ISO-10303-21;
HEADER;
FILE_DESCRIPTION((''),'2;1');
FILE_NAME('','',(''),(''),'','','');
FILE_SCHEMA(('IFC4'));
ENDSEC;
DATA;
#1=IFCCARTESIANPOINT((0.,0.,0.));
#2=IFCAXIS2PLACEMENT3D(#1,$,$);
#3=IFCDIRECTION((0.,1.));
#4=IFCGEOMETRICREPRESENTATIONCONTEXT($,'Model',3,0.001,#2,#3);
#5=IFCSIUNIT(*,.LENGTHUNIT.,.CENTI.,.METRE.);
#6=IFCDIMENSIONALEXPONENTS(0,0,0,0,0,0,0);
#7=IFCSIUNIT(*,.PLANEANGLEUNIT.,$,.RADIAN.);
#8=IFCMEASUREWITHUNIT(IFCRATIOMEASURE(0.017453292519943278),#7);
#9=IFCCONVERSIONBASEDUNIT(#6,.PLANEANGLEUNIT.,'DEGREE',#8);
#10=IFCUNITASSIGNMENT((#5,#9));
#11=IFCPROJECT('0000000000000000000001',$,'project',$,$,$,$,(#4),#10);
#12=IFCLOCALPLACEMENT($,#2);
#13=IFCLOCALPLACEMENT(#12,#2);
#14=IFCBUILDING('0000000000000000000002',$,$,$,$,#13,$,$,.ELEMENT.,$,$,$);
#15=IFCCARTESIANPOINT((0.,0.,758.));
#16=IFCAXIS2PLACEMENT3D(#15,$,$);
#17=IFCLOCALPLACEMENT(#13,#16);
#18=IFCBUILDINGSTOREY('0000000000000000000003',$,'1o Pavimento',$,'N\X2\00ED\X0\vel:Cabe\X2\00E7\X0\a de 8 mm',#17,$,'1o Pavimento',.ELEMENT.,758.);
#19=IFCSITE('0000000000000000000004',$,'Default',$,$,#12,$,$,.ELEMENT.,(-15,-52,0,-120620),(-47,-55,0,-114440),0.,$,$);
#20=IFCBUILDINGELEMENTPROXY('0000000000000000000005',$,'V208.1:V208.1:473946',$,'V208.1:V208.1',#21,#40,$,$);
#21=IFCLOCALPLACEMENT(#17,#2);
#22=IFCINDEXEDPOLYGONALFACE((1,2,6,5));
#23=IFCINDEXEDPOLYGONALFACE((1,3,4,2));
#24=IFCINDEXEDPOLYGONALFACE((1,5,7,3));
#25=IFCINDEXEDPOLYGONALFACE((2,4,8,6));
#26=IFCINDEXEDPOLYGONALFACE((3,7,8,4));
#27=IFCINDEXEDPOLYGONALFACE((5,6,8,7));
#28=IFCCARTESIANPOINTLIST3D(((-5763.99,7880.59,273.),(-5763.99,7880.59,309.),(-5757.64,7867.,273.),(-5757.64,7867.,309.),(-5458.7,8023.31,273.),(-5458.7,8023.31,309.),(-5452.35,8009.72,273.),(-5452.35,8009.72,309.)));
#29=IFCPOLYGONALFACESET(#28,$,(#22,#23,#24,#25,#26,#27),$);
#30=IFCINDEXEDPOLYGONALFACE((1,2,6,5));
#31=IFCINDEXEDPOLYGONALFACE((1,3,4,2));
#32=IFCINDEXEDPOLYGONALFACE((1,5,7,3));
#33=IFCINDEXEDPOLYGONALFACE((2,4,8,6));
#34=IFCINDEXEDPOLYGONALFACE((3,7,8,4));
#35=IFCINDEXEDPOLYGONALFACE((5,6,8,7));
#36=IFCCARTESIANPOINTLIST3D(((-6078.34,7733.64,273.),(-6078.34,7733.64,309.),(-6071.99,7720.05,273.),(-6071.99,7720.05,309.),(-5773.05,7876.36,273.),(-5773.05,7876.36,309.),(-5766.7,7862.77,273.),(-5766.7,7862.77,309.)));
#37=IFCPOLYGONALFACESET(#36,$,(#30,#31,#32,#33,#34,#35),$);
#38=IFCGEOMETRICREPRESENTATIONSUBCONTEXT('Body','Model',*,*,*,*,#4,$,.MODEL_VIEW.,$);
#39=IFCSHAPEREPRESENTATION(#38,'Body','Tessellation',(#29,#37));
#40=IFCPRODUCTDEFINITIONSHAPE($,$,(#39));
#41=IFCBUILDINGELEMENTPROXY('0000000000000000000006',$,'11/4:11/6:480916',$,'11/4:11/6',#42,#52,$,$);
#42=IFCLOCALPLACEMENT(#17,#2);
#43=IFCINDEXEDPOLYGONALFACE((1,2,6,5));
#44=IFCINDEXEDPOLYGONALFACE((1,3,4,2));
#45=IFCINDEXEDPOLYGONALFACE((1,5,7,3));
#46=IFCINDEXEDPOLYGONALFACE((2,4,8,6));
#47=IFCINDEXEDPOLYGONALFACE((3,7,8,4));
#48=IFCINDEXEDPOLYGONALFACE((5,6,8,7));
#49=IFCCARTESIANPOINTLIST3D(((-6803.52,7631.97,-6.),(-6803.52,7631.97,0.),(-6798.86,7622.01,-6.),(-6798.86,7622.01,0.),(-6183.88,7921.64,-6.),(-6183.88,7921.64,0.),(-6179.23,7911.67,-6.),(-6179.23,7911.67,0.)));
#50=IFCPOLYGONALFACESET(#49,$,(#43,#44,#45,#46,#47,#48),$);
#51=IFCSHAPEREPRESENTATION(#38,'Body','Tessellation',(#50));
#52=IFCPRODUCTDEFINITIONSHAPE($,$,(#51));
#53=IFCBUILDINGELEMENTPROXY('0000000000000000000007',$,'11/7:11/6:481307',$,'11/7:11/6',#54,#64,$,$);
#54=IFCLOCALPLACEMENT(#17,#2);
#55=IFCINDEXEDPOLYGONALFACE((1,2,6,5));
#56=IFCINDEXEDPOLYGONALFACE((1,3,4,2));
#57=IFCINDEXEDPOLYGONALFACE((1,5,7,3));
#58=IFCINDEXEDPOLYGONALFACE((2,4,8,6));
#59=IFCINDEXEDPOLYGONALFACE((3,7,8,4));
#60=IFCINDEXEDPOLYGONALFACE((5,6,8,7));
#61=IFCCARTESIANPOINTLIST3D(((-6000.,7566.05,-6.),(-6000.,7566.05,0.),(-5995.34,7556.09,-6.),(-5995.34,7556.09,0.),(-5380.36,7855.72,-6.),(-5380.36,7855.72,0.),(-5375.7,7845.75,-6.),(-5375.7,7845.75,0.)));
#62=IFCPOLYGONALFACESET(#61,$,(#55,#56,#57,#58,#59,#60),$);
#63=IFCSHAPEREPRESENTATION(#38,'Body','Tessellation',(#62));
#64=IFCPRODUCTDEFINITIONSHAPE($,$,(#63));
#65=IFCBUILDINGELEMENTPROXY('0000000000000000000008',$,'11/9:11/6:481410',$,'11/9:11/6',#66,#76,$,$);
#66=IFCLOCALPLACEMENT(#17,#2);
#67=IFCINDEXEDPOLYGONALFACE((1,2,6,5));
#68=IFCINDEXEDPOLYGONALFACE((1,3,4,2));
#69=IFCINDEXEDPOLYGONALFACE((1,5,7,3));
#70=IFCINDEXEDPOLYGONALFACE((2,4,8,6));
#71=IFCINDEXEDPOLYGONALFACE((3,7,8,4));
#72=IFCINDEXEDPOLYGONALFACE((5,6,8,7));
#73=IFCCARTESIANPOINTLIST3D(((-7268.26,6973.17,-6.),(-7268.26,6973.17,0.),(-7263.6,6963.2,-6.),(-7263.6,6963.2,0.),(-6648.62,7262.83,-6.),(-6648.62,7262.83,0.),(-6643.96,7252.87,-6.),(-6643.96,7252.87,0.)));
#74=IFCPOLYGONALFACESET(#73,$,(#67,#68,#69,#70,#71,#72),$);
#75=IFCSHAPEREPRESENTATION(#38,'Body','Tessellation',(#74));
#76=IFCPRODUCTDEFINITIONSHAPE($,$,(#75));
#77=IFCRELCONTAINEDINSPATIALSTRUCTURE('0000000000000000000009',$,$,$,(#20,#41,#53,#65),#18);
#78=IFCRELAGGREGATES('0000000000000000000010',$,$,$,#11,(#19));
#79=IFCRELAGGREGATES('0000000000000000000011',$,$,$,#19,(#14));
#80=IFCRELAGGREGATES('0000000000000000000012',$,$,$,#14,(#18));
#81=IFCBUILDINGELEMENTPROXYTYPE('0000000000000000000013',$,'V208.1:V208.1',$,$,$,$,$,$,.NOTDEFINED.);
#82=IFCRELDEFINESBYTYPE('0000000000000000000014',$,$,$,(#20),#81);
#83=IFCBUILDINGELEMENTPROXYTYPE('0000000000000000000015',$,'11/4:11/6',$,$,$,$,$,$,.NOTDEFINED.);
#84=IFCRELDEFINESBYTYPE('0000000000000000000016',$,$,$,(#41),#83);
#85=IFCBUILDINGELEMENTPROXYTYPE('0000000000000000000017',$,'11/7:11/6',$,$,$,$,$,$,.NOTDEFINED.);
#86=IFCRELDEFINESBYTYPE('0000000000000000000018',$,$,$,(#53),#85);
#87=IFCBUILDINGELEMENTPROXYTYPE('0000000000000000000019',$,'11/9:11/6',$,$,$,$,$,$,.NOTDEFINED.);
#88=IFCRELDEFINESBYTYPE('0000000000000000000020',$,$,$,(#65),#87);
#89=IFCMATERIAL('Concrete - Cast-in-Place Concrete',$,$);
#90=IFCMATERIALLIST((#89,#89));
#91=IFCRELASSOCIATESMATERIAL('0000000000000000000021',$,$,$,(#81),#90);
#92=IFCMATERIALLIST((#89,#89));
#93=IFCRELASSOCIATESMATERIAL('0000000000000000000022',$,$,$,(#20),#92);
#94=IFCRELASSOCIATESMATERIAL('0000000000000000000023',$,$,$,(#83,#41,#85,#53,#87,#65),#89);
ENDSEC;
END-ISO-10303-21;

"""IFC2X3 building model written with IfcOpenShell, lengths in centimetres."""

from ifc_helpers import new_model, entity, si_unit, converted_unit, direction, frame, frame_2d, origin, origin_2d_with_axis, place, context, subcontext, project, spatial, rectangle, extrude, source, transform, mapped, material, material_list, type_object, type_shapes, element, save


model = new_model("IFC2X3")

# Units and contexts
model_context = context("Model", 3, precision=0.001, world=origin(), true_north=direction((0.0, 1.0)))
body_context = subcontext(model_context, "Body", "Model", "MODEL_VIEW")
ifc_project = project(units=[si_unit("LENGTHUNIT", "METRE", prefix="CENTI"), converted_unit("PLANEANGLEUNIT", "DEGREE", entity("IfcRatioMeasure", 0.017453292519943278), si_unit("PLANEANGLEUNIT", "RADIAN"), dimensions=[0, 0, 0, 0, 0, 0, 0])], contexts=[model_context])

# Site, building, storey
site_placement = place(None, origin())
site = spatial("IfcSite", under=ifc_project, at=site_placement, Name="Default", CompositionType="ELEMENT", RefLatitude=(-15, -52, 0, -120620), RefLongitude=(-47, -55, 0, -114440), RefElevation=0.0)
building_placement = place(site_placement, origin())
building = spatial("IfcBuilding", under=site, at=building_placement, CompositionType="ELEMENT")
storey_placement = place(building_placement, frame((0.0, 0.0, 758.0)))
storey = spatial("IfcBuildingStorey", under=building, at=storey_placement, Name="1o Pavimento", ObjectType="Nível:Cabeça de 8 mm", LongName="1o Pavimento", CompositionType="ELEMENT", Elevation=758.0)

# Building element proxies
ifc_material_1 = material(Name="Concrete - Cast-in-Place Concrete")
ifc_material_list_1 = material_list([ifc_material_1, ifc_material_1])
ifc_material_list_2 = material_list([ifc_material_1, ifc_material_1])
building_element_proxy_type_1 = type_object("IfcBuildingElementProxyType", Name="V208.1:V208.1", PredefinedType="NOTDEFINED", material=ifc_material_list_2)
shared_shape_1 = source(origin(), body_context, "Body", "SweptSolid", [
    extrude(rectangle(XDim=337.0, YDim=15.0, at=origin_2d_with_axis()), frame((470.17, 225.1, 0.0), z_axis=(0.0, 0.0, 1.0), x_axis=(-0.905902, -0.423488, 0.0)), (0.0, 0.0, 1.0), 36.0),
    extrude(rectangle(XDim=337.0, YDim=15.0, at=frame_2d((0.0, 0.0), x_axis=(1.0, 0.0))), frame((155.82, 78.15, 0.0), z_axis=(0.0, 0.0, 1.0), x_axis=(-0.905902, -0.423488, 0.0)), (0.0, 0.0, 1.0), 36.0),
])
type_shapes(building_element_proxy_type_1, [shared_shape_1])
proxy_1_placement = place(storey_placement, frame((-6078.34, 7720.05, 273.0)))
element("IfcBuildingElementProxy", 1, at=proxy_1_placement, inside=storey, type_object=building_element_proxy_type_1, material=ifc_material_list_1, Name="V208.1:V208.1:473946", ObjectType="V208.1:V208.1", context=body_context, shape_type="MappedRepresentation", body=[
    mapped(shared_shape_1, transform((0.0, 0.0, 0.0), scale=1.0)),
])
building_element_proxy_type_2 = type_object("IfcBuildingElementProxyType", Name="11/4:11/6", PredefinedType="NOTDEFINED", material=ifc_material_1)
shared_shape_2 = source(origin(), body_context, "Body", "SweptSolid", [
    extrude(rectangle(XDim=11.0, YDim=684.0, at=frame_2d((0.0, 0.0), x_axis=(1.0, 0.0))), frame((312.15, 149.82, 0.0), z_axis=(0.0, 0.0, 1.0), x_axis=(0.423488, -0.905902, 0.0)), (0.0, 0.0, 1.0), 6.0),
])
type_shapes(building_element_proxy_type_2, [shared_shape_2])
proxy_2_placement = place(storey_placement, frame((-6803.52, 7622.01, -6.0)))
element("IfcBuildingElementProxy", 2, at=proxy_2_placement, inside=storey, type_object=building_element_proxy_type_2, material=ifc_material_1, Name="11/4:11/6:480916", ObjectType="11/4:11/6", context=body_context, shape_type="MappedRepresentation", body=[
    mapped(shared_shape_2, transform((0.0, 0.0, 0.0), scale=1.0)),
])
building_element_proxy_type_3 = type_object("IfcBuildingElementProxyType", Name="11/7:11/6", PredefinedType="NOTDEFINED", material=ifc_material_1)
shared_shape_3 = source(origin(), body_context, "Body", "SweptSolid", [
    extrude(rectangle(XDim=11.0, YDim=684.0, at=frame_2d((0.0, 0.0), x_axis=(1.0, 0.0))), frame((312.15, 149.82, 0.0), z_axis=(0.0, 0.0, 1.0), x_axis=(0.423488, -0.905902, 0.0)), (0.0, 0.0, 1.0), 6.0),
])
type_shapes(building_element_proxy_type_3, [shared_shape_3])
proxy_3_placement = place(storey_placement, frame((-6000.0, 7556.09, -6.0)))
element("IfcBuildingElementProxy", 3, at=proxy_3_placement, inside=storey, type_object=building_element_proxy_type_3, material=ifc_material_1, Name="11/7:11/6:481307", ObjectType="11/7:11/6", context=body_context, shape_type="MappedRepresentation", body=[
    mapped(shared_shape_3, transform((0.0, 0.0, 0.0), scale=1.0)),
])
building_element_proxy_type_4 = type_object("IfcBuildingElementProxyType", Name="11/9:11/6", PredefinedType="NOTDEFINED", material=ifc_material_1)
shared_shape_4 = source(origin(), body_context, "Body", "SweptSolid", [
    extrude(rectangle(XDim=11.0, YDim=684.0, at=frame_2d((0.0, 0.0), x_axis=(1.0, 0.0))), frame((312.15, 149.82, 0.0), z_axis=(0.0, 0.0, 1.0), x_axis=(0.423488, -0.905902, 0.0)), (0.0, 0.0, 1.0), 6.0),
])
type_shapes(building_element_proxy_type_4, [shared_shape_4])
proxy_4_placement = place(storey_placement, frame((-7268.26, 6963.2, -6.0)))
element("IfcBuildingElementProxy", 4, at=proxy_4_placement, inside=storey, type_object=building_element_proxy_type_4, material=ifc_material_1, Name="11/9:11/6:481410", ObjectType="11/9:11/6", context=body_context, shape_type="MappedRepresentation", body=[
    mapped(shared_shape_4, transform((0.0, 0.0, 0.0), scale=1.0)),
])

save(model, "model.ifc")
